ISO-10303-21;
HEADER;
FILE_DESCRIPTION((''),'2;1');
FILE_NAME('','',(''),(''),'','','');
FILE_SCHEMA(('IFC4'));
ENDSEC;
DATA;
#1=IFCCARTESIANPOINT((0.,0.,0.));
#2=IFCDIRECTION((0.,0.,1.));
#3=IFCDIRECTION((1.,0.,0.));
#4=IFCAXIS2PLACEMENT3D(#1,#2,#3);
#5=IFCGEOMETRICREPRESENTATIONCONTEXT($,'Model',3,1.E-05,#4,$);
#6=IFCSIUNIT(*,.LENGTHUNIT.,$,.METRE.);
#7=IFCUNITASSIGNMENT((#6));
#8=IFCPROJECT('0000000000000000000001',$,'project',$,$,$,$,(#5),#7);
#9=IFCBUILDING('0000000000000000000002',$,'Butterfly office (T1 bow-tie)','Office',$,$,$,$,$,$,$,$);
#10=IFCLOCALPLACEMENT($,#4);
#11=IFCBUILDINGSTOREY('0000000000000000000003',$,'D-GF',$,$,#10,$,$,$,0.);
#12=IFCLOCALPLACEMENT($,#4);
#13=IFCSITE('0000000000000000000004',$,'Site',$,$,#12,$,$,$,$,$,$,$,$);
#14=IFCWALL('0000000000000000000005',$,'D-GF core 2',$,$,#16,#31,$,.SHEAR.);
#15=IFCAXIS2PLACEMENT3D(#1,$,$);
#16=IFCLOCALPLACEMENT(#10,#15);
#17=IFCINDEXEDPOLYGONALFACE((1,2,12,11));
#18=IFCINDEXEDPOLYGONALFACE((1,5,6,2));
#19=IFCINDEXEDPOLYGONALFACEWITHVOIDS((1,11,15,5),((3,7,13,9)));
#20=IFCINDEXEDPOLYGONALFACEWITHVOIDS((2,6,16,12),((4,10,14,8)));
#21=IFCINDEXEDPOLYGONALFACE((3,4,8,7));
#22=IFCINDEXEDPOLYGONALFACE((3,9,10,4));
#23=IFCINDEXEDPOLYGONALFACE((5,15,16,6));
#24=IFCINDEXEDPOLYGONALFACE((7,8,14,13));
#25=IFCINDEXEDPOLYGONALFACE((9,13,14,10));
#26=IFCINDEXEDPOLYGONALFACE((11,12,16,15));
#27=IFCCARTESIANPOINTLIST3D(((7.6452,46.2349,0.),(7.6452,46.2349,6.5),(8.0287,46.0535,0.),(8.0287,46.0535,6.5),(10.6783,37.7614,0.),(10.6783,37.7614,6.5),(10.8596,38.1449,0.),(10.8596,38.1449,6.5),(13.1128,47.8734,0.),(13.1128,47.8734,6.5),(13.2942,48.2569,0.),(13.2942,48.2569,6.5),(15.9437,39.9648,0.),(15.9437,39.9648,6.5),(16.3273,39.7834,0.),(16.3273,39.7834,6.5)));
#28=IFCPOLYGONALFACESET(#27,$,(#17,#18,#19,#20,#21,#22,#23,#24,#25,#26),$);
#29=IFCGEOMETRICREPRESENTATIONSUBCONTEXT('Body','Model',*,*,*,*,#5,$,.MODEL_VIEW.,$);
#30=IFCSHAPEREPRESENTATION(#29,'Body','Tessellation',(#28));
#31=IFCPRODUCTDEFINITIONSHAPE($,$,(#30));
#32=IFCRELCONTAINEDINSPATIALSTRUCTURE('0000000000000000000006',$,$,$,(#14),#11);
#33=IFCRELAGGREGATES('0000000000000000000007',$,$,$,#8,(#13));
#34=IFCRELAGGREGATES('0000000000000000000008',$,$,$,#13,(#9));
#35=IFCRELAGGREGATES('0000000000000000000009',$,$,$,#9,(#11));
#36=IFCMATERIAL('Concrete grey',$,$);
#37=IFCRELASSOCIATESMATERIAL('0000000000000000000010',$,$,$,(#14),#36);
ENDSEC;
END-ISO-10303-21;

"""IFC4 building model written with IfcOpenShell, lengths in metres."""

from ifc_helpers import new_model, si_unit, origin_with_axes, place, context, subcontext, project, spatial, polyline, outline, extrude, material, element, save


model = new_model("IFC4")

# Units and contexts
model_context = context("Model", 3, precision=1e-05, world=origin_with_axes())
body_context = subcontext(model_context, "Body", "Model", "MODEL_VIEW")
ifc_project = project(units=[si_unit("LENGTHUNIT", "METRE")], contexts=[model_context])

# Site, building, storey
site_placement = place(None, origin_with_axes())
site = spatial("IfcSite", under=ifc_project, at=site_placement, Name="Site")
building = spatial("IfcBuilding", under=site, Name="Butterfly office (T1 bow-tie)", Description="Office")
storey_placement = place(None, origin_with_axes())
storey = spatial("IfcBuildingStorey", under=building, at=storey_placement, Name="D-GF", Elevation=0.0)

# Shared definitions
ifc_material_1 = material(Name="Concrete grey")

# Wall
wall_1_placement = place(storey_placement, origin_with_axes())
element("IfcWall", 1, at=wall_1_placement, inside=storey, material=ifc_material_1, Name="D-GF core 2", PredefinedType="SHEAR", context=body_context, shape_type="SweptSolid", body=[
    extrude(outline(polyline([(10.6783, 37.7614), (16.3273, 39.7834), (13.2942, 48.2569), (7.6452, 46.2349), (10.6783, 37.7614)]), holes=[polyline([(10.8596, 38.1449), (15.9437, 39.9648), (13.1128, 47.8734), (8.0287, 46.0535), (10.8596, 38.1449)])]), origin_with_axes(), (0.0, 0.0, 1.0), 6.5),
])

save(model, "model.ifc")
